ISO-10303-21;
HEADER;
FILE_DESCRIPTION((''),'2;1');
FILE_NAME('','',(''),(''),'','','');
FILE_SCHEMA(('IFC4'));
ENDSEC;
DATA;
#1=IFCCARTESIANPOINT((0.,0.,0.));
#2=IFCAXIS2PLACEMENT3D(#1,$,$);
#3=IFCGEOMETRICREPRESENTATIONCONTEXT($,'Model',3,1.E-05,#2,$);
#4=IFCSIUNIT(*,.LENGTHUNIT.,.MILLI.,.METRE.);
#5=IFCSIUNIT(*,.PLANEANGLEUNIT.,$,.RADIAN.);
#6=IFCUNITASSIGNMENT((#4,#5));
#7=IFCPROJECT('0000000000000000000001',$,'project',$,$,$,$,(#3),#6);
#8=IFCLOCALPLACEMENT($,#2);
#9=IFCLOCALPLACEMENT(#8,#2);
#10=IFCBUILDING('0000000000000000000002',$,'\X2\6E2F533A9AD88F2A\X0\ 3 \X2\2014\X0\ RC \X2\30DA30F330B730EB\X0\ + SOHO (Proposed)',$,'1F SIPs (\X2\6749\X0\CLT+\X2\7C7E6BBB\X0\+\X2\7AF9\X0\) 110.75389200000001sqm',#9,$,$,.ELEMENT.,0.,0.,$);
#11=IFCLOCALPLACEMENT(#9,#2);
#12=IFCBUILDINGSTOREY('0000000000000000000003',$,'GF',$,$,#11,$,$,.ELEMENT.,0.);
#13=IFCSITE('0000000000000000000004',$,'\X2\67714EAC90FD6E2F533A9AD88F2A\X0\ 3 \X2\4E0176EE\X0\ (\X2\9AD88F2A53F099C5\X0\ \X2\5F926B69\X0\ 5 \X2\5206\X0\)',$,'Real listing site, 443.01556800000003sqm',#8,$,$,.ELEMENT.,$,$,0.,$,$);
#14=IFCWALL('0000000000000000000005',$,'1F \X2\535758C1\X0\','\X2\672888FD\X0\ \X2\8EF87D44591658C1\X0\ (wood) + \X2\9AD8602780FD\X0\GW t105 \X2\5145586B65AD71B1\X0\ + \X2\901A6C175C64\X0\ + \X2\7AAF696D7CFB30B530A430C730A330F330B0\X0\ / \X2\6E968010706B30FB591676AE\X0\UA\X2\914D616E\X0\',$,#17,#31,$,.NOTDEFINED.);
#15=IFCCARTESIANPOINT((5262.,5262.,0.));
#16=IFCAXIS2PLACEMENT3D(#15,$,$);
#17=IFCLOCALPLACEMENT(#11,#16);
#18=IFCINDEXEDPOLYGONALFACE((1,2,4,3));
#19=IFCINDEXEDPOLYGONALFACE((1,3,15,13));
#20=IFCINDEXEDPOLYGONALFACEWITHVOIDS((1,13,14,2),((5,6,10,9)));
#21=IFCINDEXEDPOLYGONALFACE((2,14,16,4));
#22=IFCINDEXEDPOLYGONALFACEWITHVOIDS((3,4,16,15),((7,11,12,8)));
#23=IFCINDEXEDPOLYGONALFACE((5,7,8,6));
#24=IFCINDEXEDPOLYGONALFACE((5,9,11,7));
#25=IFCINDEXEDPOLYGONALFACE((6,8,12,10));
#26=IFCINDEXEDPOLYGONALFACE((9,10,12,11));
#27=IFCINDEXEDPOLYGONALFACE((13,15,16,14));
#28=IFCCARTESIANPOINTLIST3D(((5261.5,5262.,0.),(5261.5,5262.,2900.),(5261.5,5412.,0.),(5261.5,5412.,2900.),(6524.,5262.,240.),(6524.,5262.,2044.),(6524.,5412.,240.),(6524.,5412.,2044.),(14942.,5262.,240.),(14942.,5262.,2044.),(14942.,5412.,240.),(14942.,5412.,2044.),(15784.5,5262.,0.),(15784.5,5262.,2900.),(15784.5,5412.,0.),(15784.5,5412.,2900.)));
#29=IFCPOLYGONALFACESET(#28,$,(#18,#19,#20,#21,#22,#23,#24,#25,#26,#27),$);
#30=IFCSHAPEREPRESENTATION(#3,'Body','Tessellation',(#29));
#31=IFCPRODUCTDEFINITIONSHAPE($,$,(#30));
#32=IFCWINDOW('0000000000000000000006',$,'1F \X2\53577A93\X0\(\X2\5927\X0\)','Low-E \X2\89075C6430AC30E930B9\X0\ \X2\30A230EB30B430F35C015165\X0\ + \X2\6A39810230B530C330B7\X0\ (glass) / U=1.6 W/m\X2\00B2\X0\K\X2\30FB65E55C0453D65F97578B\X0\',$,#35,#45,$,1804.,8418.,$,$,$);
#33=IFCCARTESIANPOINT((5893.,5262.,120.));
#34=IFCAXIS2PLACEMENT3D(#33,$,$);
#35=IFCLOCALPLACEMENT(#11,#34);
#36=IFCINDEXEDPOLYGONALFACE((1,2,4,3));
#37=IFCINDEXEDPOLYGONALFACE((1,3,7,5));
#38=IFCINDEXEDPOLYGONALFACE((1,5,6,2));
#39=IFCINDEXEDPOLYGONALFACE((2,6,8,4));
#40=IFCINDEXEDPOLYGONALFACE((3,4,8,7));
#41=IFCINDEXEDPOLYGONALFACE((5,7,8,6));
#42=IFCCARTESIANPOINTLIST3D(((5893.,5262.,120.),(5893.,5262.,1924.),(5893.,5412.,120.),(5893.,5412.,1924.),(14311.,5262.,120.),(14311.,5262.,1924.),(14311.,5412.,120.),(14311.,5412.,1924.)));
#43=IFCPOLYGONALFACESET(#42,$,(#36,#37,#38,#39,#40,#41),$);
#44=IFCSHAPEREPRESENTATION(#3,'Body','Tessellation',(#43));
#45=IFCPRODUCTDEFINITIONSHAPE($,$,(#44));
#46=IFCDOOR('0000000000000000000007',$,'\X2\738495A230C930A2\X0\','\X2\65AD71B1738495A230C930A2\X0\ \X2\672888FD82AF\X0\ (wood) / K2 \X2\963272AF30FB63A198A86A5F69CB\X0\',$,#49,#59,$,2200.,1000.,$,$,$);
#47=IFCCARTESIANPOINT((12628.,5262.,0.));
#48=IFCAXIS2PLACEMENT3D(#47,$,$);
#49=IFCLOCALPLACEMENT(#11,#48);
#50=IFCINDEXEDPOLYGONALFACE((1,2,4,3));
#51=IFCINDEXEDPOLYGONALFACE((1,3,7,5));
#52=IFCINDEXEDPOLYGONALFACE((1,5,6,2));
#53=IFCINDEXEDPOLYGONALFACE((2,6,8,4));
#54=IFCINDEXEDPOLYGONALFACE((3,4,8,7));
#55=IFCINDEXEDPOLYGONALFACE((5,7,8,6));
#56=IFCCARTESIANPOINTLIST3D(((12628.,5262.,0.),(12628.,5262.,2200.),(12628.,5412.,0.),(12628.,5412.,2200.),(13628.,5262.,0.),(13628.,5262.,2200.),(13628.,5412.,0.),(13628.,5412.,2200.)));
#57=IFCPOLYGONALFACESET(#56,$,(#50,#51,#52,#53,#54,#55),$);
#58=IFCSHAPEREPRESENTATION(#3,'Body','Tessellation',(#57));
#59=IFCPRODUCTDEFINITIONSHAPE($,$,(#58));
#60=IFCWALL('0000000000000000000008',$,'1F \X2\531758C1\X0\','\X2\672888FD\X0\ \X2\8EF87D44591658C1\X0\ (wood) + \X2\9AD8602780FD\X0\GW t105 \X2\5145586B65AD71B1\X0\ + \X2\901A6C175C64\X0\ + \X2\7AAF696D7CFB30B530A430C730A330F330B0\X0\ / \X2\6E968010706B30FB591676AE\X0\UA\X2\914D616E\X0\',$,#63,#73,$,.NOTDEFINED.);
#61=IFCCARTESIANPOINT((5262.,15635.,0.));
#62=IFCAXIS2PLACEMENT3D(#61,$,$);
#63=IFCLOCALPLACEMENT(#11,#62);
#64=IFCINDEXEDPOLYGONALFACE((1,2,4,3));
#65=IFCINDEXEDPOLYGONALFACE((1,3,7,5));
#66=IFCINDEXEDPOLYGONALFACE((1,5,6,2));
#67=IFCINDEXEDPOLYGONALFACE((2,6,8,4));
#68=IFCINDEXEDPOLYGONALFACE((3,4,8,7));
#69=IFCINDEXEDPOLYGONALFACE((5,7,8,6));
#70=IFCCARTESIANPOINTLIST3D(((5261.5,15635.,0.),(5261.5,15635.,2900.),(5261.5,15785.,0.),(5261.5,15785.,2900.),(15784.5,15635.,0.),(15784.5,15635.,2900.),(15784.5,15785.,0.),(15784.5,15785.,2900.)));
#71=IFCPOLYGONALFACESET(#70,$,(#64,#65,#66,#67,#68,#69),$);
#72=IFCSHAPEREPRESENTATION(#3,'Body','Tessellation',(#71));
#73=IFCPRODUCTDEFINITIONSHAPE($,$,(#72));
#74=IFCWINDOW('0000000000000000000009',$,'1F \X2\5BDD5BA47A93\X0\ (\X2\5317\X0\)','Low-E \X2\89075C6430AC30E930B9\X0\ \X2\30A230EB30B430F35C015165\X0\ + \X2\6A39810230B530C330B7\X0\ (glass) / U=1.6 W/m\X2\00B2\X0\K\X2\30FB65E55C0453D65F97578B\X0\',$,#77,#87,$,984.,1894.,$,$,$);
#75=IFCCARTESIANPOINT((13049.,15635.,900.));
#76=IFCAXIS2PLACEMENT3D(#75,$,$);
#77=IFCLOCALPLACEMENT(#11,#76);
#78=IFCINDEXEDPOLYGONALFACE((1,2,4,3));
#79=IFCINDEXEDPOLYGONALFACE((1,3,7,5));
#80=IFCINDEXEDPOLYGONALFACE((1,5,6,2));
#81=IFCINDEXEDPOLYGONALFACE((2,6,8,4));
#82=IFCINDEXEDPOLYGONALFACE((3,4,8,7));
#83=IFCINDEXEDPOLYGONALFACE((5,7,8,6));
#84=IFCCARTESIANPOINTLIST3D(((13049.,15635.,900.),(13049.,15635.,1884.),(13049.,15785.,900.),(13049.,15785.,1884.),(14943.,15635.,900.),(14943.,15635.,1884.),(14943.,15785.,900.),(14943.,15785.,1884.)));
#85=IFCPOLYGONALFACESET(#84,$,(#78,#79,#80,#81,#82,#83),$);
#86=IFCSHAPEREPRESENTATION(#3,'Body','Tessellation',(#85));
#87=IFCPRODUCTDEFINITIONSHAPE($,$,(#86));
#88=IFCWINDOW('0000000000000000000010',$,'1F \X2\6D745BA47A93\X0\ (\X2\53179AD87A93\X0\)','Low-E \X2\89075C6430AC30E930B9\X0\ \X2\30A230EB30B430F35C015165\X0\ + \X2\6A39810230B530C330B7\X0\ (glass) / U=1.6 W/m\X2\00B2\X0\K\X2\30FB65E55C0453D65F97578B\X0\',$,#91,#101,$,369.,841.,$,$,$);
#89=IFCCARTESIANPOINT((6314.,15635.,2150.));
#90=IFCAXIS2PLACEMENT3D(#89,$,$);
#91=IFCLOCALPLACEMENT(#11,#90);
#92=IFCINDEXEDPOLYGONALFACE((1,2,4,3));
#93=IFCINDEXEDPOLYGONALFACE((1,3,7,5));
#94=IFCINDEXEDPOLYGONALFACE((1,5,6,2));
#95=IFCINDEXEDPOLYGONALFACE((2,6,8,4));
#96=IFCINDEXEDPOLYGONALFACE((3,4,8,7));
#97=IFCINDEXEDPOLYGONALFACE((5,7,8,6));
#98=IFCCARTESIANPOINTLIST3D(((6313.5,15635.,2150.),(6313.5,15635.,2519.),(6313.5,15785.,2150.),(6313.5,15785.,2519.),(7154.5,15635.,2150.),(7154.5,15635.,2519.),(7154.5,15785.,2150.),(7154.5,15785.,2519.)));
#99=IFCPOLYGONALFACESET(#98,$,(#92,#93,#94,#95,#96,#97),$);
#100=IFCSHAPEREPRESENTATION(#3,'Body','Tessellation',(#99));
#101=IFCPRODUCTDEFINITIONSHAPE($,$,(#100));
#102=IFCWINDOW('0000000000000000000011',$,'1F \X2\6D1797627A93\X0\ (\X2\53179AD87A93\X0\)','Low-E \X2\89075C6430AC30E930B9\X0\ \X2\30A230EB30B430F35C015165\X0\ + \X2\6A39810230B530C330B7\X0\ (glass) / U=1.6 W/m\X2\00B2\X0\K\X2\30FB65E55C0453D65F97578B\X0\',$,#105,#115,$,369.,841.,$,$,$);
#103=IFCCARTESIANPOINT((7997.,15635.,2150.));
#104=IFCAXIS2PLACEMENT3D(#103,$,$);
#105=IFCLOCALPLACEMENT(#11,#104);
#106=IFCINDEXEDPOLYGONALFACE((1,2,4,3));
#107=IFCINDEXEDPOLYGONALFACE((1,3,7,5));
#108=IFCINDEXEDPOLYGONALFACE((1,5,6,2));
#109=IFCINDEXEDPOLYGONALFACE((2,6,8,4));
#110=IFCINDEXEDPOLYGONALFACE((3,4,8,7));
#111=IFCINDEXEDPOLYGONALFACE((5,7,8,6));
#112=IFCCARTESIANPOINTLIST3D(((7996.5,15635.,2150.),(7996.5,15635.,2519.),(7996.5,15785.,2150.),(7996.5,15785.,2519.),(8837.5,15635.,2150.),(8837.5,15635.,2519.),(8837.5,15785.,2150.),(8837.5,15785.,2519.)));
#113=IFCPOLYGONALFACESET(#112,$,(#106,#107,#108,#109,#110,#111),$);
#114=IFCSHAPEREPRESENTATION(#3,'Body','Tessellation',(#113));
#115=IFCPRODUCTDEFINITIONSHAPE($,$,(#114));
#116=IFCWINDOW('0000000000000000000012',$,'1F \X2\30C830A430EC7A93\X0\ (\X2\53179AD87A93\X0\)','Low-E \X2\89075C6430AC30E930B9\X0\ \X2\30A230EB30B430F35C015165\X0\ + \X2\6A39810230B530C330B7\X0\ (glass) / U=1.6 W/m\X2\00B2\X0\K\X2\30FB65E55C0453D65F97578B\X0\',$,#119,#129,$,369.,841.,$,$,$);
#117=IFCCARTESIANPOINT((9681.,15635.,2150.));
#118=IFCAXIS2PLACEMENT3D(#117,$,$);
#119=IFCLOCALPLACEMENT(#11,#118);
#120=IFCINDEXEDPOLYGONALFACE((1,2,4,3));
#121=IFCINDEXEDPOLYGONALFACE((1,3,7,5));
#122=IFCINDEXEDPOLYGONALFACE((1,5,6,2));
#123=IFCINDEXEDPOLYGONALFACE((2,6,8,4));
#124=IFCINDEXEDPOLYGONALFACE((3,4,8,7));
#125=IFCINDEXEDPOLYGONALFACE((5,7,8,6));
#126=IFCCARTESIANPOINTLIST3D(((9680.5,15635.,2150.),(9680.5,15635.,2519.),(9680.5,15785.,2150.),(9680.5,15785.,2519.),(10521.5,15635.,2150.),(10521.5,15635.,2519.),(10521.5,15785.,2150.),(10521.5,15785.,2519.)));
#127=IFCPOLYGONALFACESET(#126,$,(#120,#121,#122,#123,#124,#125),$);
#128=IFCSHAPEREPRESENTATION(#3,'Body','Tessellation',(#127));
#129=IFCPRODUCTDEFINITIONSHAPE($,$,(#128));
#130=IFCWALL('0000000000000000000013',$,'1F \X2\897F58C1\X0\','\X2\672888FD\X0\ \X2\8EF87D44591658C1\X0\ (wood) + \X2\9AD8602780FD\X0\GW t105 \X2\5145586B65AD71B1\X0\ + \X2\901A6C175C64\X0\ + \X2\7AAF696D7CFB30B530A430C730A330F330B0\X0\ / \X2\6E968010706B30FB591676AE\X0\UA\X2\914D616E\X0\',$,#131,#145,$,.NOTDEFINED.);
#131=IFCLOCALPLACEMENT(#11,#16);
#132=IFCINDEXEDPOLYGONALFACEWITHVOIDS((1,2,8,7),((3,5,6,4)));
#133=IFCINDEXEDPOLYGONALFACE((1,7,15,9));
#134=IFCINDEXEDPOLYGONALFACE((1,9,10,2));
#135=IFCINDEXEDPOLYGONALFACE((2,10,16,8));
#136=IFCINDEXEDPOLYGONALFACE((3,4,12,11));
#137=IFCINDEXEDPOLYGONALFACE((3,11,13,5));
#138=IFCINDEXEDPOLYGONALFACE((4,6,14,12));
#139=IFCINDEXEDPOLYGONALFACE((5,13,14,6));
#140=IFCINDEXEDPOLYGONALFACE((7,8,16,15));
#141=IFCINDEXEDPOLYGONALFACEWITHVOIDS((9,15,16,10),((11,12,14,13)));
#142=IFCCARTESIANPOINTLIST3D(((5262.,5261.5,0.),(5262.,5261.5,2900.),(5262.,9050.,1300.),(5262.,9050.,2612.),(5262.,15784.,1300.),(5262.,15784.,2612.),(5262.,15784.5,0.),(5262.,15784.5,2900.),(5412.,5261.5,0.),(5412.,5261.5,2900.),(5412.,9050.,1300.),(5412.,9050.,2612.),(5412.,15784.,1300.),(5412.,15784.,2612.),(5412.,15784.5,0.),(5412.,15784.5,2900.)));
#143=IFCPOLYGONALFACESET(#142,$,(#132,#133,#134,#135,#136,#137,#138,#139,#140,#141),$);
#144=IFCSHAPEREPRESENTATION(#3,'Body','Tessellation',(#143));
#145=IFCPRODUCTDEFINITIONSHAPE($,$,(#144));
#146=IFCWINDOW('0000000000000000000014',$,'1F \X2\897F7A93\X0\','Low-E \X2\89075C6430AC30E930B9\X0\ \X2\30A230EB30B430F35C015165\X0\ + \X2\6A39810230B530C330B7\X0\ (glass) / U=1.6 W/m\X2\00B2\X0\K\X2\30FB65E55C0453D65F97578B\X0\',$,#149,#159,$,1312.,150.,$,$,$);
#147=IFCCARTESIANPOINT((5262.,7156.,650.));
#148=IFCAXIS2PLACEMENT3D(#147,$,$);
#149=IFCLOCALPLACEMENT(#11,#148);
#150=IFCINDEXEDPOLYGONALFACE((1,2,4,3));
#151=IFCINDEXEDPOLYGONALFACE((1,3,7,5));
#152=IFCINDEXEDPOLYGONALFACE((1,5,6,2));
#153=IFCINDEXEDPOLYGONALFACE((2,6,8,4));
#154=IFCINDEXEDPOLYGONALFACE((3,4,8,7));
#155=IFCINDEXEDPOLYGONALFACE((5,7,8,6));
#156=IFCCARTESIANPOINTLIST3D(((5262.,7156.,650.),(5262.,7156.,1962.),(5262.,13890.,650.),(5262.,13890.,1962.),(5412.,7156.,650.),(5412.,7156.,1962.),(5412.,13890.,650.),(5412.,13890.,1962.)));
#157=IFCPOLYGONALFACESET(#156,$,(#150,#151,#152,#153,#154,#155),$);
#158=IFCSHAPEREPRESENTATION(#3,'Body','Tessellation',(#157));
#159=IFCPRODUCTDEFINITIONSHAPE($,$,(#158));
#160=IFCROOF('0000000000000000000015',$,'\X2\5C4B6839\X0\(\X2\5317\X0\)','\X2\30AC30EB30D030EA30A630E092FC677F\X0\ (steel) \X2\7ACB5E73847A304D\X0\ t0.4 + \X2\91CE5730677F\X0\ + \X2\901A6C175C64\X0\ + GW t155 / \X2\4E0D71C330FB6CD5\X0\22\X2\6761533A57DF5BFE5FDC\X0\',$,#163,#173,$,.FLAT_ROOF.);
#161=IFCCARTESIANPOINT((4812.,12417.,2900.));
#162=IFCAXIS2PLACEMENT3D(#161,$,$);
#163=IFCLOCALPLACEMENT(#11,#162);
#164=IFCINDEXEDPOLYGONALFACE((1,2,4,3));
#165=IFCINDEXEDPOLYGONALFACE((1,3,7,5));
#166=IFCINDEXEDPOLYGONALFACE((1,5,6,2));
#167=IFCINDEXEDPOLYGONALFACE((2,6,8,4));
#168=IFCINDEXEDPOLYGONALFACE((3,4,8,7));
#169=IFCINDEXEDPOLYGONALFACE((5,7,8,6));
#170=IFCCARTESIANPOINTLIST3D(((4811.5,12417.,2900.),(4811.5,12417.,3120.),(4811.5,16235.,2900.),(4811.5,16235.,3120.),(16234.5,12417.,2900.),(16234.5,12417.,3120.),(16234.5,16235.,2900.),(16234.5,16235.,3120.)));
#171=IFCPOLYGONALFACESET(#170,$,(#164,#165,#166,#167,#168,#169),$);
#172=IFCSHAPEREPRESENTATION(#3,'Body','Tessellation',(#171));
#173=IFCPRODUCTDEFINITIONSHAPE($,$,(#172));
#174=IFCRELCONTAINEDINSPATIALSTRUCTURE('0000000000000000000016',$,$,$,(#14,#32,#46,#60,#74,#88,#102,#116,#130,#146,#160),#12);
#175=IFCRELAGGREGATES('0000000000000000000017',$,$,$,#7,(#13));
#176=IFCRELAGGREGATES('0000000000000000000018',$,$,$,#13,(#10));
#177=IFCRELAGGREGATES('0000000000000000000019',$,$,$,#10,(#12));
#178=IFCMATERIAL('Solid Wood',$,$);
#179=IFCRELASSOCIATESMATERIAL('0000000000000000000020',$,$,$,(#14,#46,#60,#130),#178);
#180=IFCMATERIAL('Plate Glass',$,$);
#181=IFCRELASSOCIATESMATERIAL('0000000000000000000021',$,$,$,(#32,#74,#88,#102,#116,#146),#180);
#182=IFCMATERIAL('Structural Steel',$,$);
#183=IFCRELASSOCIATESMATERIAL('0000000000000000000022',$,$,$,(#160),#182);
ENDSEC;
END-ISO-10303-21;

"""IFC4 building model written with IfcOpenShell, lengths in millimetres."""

from ifc_helpers import new_model, si_unit, frame, frame_2d, origin, place, context, project, spatial, rectangle, extrude, material, element, fill, save


model = new_model("IFC4")

# Units and contexts
model_context = context("Model", 3, precision=1e-05, world=origin())
ifc_project = project(units=[si_unit("LENGTHUNIT", "METRE", prefix="MILLI"), si_unit("PLANEANGLEUNIT", "RADIAN")], contexts=[model_context])

# Site, building, storey
site_placement = place(None, origin())
site = spatial("IfcSite", under=ifc_project, at=site_placement, Name="東京都港区高輪 3 丁目 (高輪台駅 徒歩 5 分)", ObjectType="Real listing site, 443.01556800000003sqm", CompositionType="ELEMENT", RefElevation=0.0)
building_placement = place(site_placement, origin())
building = spatial("IfcBuilding", under=site, at=building_placement, Name="港区高輪 3 — RC ペンシル + SOHO (Proposed)", ObjectType="1F SIPs (杉CLT+籾殻+竹) 110.75389200000001sqm", CompositionType="ELEMENT", ElevationOfRefHeight=0.0, ElevationOfTerrain=0.0)
storey_placement = place(building_placement, origin())
storey = spatial("IfcBuildingStorey", under=building, at=storey_placement, Name="GF", CompositionType="ELEMENT", Elevation=0.0)

# Shared definitions
ifc_material_1 = material(Name="Solid Wood")

# Wall, openings, window, door
wall_1_placement = place(storey_placement, frame((5262.0, 5262.0, 0.0)))
wall_1 = element("IfcWall", 1, at=wall_1_placement, inside=storey, material=ifc_material_1, Name="1F 南壁", Description="木製 軸組外壁 (wood) + 高性能GW t105 充填断熱 + 通気層 + 窯業系サイディング / 準耐火・外皮UA配慮", PredefinedType="NOTDEFINED", context=model_context, shape_type="SweptSolid", body=[
    extrude(rectangle(XDim=10523.0, YDim=150.0, at=frame_2d((5261.0, 75.0))), frame((5262.0, 5262.0, 0.0)), (0.0, 0.0, 1.0), 2900.0),
])
opening_1_placement = place(storey_placement, frame((5893.0, 5262.0, 120.0)))
opening_1 = element("IfcOpeningElement", 2, at=opening_1_placement, cuts=wall_1, PredefinedType="NOTDEFINED", context=model_context, shape_type="SweptSolid", body=[
    extrude(rectangle(XDim=8418.0, YDim=150.0, at=frame_2d((4209.0, 75.0))), frame((5893.0, 5262.0, 120.0)), (0.0, 0.0, 1.0), 1804.0),
])
opening_2_placement = place(storey_placement, frame((12628.0, 5262.0, 0.0)))
opening_2 = element("IfcOpeningElement", 3, at=opening_2_placement, cuts=wall_1, PredefinedType="NOTDEFINED", context=model_context, shape_type="SweptSolid", body=[
    extrude(rectangle(XDim=1000.0, YDim=150.0, at=frame_2d((500.0, 75.0))), frame((12628.0, 5262.0, 0.0)), (0.0, 0.0, 1.0), 2200.0),
])
ifc_material_2 = material(Name="Plate Glass")
window_1_placement = place(storey_placement, frame((5893.0, 5262.0, 120.0)))
window_1 = element("IfcWindow", 4, at=window_1_placement, inside=storey, material=ifc_material_2, Name="1F 南窓(大)", Description="Low-E 複層ガラス アルゴン封入 + 樹脂サッシ (glass) / U=1.6 W/m²K・日射取得型", OverallHeight=1804.0, OverallWidth=8418.0, context=model_context, shape_type="SweptSolid", body=[
    extrude(rectangle(XDim=8418.0, YDim=150.0, at=frame_2d((4209.0, 75.0))), frame((5893.0, 5262.0, 120.0)), (0.0, 0.0, 1.0), 1804.0),
])
fill(opening_1, window_1)
door_1_placement = place(storey_placement, frame((12628.0, 5262.0, 0.0)))
door_1 = element("IfcDoor", 5, at=door_1_placement, inside=storey, material=ifc_material_1, Name="玄関ドア", Description="断熱玄関ドア 木製芯 (wood) / K2 防犯・採風機構", OverallHeight=2200.0, OverallWidth=1000.0, context=model_context, shape_type="SweptSolid", body=[
    extrude(rectangle(XDim=1000.0, YDim=150.0, at=frame_2d((500.0, 75.0))), frame((12628.0, 5262.0, 0.0)), (0.0, 0.0, 1.0), 2200.0),
])
fill(opening_2, door_1)

# Wall, openings, windows
wall_2_placement = place(storey_placement, frame((5262.0, 15635.0, 0.0)))
wall_2 = element("IfcWall", 6, at=wall_2_placement, inside=storey, material=ifc_material_1, Name="1F 北壁", Description="木製 軸組外壁 (wood) + 高性能GW t105 充填断熱 + 通気層 + 窯業系サイディング / 準耐火・外皮UA配慮", PredefinedType="NOTDEFINED", context=model_context, shape_type="SweptSolid", body=[
    extrude(rectangle(XDim=10523.0, YDim=150.0, at=frame_2d((5261.0, 75.0))), frame((5262.0, 15635.0, 0.0)), (0.0, 0.0, 1.0), 2900.0),
])
opening_3_placement = place(storey_placement, frame((13049.0, 15635.0, 900.0)))
opening_3 = element("IfcOpeningElement", 7, at=opening_3_placement, cuts=wall_2, PredefinedType="NOTDEFINED", context=model_context, shape_type="SweptSolid", body=[
    extrude(rectangle(XDim=1894.0, YDim=150.0, at=frame_2d((947.0, 75.0))), frame((13049.0, 15635.0, 900.0)), (0.0, 0.0, 1.0), 984.0),
])
opening_4_placement = place(storey_placement, frame((6314.0, 15635.0, 2150.0)))
opening_4 = element("IfcOpeningElement", 8, at=opening_4_placement, cuts=wall_2, PredefinedType="NOTDEFINED", context=model_context, shape_type="SweptSolid", body=[
    extrude(rectangle(XDim=841.0, YDim=150.0, at=frame_2d((420.0, 75.0))), frame((6314.0, 15635.0, 2150.0)), (0.0, 0.0, 1.0), 369.0),
])
opening_5_placement = place(storey_placement, frame((7997.0, 15635.0, 2150.0)))
opening_5 = element("IfcOpeningElement", 9, at=opening_5_placement, cuts=wall_2, PredefinedType="NOTDEFINED", context=model_context, shape_type="SweptSolid", body=[
    extrude(rectangle(XDim=841.0, YDim=150.0, at=frame_2d((420.0, 75.0))), frame((7997.0, 15635.0, 2150.0)), (0.0, 0.0, 1.0), 369.0),
])
opening_6_placement = place(storey_placement, frame((9681.0, 15635.0, 2150.0)))
opening_6 = element("IfcOpeningElement", 10, at=opening_6_placement, cuts=wall_2, PredefinedType="NOTDEFINED", context=model_context, shape_type="SweptSolid", body=[
    extrude(rectangle(XDim=841.0, YDim=150.0, at=frame_2d((420.0, 75.0))), frame((9681.0, 15635.0, 2150.0)), (0.0, 0.0, 1.0), 369.0),
])
window_2_placement = place(storey_placement, frame((13049.0, 15635.0, 900.0)))
window_2 = element("IfcWindow", 11, at=window_2_placement, inside=storey, material=ifc_material_2, Name="1F 寝室窓 (北)", Description="Low-E 複層ガラス アルゴン封入 + 樹脂サッシ (glass) / U=1.6 W/m²K・日射取得型", OverallHeight=984.0, OverallWidth=1894.0, context=model_context, shape_type="SweptSolid", body=[
    extrude(rectangle(XDim=1894.0, YDim=150.0, at=frame_2d((947.0, 75.0))), frame((13049.0, 15635.0, 900.0)), (0.0, 0.0, 1.0), 984.0),
])
fill(opening_3, window_2)
window_3_placement = place(storey_placement, frame((6314.0, 15635.0, 2150.0)))
window_3 = element("IfcWindow", 12, at=window_3_placement, inside=storey, material=ifc_material_2, Name="1F 浴室窓 (北高窓)", Description="Low-E 複層ガラス アルゴン封入 + 樹脂サッシ (glass) / U=1.6 W/m²K・日射取得型", OverallHeight=369.0, OverallWidth=841.0, context=model_context, shape_type="SweptSolid", body=[
    extrude(rectangle(XDim=841.0, YDim=150.0, at=frame_2d((420.0, 75.0))), frame((6314.0, 15635.0, 2150.0)), (0.0, 0.0, 1.0), 369.0),
])
fill(opening_4, window_3)
window_4_placement = place(storey_placement, frame((7997.0, 15635.0, 2150.0)))
window_4 = element("IfcWindow", 13, at=window_4_placement, inside=storey, material=ifc_material_2, Name="1F 洗面窓 (北高窓)", Description="Low-E 複層ガラス アルゴン封入 + 樹脂サッシ (glass) / U=1.6 W/m²K・日射取得型", OverallHeight=369.0, OverallWidth=841.0, context=model_context, shape_type="SweptSolid", body=[
    extrude(rectangle(XDim=841.0, YDim=150.0, at=frame_2d((420.0, 75.0))), frame((7997.0, 15635.0, 2150.0)), (0.0, 0.0, 1.0), 369.0),
])
fill(opening_5, window_4)
window_5_placement = place(storey_placement, frame((9681.0, 15635.0, 2150.0)))
window_5 = element("IfcWindow", 14, at=window_5_placement, inside=storey, material=ifc_material_2, Name="1F トイレ窓 (北高窓)", Description="Low-E 複層ガラス アルゴン封入 + 樹脂サッシ (glass) / U=1.6 W/m²K・日射取得型", OverallHeight=369.0, OverallWidth=841.0, context=model_context, shape_type="SweptSolid", body=[
    extrude(rectangle(XDim=841.0, YDim=150.0, at=frame_2d((420.0, 75.0))), frame((9681.0, 15635.0, 2150.0)), (0.0, 0.0, 1.0), 369.0),
])
fill(opening_6, window_5)

# Wall, opening, window
wall_3_placement = place(storey_placement, frame((5262.0, 5262.0, 0.0)))
wall_3 = element("IfcWall", 15, at=wall_3_placement, inside=storey, material=ifc_material_1, Name="1F 西壁", Description="木製 軸組外壁 (wood) + 高性能GW t105 充填断熱 + 通気層 + 窯業系サイディング / 準耐火・外皮UA配慮", PredefinedType="NOTDEFINED", context=model_context, shape_type="SweptSolid", body=[
    extrude(rectangle(XDim=150.0, YDim=10523.0, at=frame_2d((75.0, 5261.0))), frame((5262.0, 5262.0, 0.0)), (0.0, 0.0, 1.0), 2900.0),
])
opening_7_placement = place(storey_placement, frame((5262.0, 7156.0, 650.0)))
opening_7 = element("IfcOpeningElement", 16, at=opening_7_placement, cuts=wall_3, PredefinedType="NOTDEFINED", context=model_context, shape_type="SweptSolid", body=[
    extrude(rectangle(XDim=150.0, YDim=6734.0, at=frame_2d((75.0, 3367.0))), frame((5262.0, 7156.0, 650.0)), (0.0, 0.0, 1.0), 1312.0),
])
window_6_placement = place(storey_placement, frame((5262.0, 7156.0, 650.0)))
window_6 = element("IfcWindow", 17, at=window_6_placement, inside=storey, material=ifc_material_2, Name="1F 西窓", Description="Low-E 複層ガラス アルゴン封入 + 樹脂サッシ (glass) / U=1.6 W/m²K・日射取得型", OverallHeight=1312.0, OverallWidth=150.0, context=model_context, shape_type="SweptSolid", body=[
    extrude(rectangle(XDim=150.0, YDim=6734.0, at=frame_2d((75.0, 3367.0))), frame((5262.0, 7156.0, 650.0)), (0.0, 0.0, 1.0), 1312.0),
])
fill(opening_7, window_6)

# Roof
ifc_material_3 = material(Name="Structural Steel")
roof_1_placement = place(storey_placement, frame((4812.0, 12417.0, 2900.0)))
element("IfcRoof", 18, at=roof_1_placement, inside=storey, material=ifc_material_3, Name="屋根(北)", Description="ガルバリウム鋼板 (steel) 立平葺き t0.4 + 野地板 + 通気層 + GW t155 / 不燃・法22条区域対応", PredefinedType="FLAT_ROOF", context=model_context, shape_type="SweptSolid", body=[
    extrude(rectangle(XDim=11423.0, YDim=3818.0, at=frame_2d((5711.0, 1909.0))), frame((4812.0, 12417.0, 2900.0)), (0.0, 0.0, 1.0), 220.0),
])

save(model, "model.ifc")
